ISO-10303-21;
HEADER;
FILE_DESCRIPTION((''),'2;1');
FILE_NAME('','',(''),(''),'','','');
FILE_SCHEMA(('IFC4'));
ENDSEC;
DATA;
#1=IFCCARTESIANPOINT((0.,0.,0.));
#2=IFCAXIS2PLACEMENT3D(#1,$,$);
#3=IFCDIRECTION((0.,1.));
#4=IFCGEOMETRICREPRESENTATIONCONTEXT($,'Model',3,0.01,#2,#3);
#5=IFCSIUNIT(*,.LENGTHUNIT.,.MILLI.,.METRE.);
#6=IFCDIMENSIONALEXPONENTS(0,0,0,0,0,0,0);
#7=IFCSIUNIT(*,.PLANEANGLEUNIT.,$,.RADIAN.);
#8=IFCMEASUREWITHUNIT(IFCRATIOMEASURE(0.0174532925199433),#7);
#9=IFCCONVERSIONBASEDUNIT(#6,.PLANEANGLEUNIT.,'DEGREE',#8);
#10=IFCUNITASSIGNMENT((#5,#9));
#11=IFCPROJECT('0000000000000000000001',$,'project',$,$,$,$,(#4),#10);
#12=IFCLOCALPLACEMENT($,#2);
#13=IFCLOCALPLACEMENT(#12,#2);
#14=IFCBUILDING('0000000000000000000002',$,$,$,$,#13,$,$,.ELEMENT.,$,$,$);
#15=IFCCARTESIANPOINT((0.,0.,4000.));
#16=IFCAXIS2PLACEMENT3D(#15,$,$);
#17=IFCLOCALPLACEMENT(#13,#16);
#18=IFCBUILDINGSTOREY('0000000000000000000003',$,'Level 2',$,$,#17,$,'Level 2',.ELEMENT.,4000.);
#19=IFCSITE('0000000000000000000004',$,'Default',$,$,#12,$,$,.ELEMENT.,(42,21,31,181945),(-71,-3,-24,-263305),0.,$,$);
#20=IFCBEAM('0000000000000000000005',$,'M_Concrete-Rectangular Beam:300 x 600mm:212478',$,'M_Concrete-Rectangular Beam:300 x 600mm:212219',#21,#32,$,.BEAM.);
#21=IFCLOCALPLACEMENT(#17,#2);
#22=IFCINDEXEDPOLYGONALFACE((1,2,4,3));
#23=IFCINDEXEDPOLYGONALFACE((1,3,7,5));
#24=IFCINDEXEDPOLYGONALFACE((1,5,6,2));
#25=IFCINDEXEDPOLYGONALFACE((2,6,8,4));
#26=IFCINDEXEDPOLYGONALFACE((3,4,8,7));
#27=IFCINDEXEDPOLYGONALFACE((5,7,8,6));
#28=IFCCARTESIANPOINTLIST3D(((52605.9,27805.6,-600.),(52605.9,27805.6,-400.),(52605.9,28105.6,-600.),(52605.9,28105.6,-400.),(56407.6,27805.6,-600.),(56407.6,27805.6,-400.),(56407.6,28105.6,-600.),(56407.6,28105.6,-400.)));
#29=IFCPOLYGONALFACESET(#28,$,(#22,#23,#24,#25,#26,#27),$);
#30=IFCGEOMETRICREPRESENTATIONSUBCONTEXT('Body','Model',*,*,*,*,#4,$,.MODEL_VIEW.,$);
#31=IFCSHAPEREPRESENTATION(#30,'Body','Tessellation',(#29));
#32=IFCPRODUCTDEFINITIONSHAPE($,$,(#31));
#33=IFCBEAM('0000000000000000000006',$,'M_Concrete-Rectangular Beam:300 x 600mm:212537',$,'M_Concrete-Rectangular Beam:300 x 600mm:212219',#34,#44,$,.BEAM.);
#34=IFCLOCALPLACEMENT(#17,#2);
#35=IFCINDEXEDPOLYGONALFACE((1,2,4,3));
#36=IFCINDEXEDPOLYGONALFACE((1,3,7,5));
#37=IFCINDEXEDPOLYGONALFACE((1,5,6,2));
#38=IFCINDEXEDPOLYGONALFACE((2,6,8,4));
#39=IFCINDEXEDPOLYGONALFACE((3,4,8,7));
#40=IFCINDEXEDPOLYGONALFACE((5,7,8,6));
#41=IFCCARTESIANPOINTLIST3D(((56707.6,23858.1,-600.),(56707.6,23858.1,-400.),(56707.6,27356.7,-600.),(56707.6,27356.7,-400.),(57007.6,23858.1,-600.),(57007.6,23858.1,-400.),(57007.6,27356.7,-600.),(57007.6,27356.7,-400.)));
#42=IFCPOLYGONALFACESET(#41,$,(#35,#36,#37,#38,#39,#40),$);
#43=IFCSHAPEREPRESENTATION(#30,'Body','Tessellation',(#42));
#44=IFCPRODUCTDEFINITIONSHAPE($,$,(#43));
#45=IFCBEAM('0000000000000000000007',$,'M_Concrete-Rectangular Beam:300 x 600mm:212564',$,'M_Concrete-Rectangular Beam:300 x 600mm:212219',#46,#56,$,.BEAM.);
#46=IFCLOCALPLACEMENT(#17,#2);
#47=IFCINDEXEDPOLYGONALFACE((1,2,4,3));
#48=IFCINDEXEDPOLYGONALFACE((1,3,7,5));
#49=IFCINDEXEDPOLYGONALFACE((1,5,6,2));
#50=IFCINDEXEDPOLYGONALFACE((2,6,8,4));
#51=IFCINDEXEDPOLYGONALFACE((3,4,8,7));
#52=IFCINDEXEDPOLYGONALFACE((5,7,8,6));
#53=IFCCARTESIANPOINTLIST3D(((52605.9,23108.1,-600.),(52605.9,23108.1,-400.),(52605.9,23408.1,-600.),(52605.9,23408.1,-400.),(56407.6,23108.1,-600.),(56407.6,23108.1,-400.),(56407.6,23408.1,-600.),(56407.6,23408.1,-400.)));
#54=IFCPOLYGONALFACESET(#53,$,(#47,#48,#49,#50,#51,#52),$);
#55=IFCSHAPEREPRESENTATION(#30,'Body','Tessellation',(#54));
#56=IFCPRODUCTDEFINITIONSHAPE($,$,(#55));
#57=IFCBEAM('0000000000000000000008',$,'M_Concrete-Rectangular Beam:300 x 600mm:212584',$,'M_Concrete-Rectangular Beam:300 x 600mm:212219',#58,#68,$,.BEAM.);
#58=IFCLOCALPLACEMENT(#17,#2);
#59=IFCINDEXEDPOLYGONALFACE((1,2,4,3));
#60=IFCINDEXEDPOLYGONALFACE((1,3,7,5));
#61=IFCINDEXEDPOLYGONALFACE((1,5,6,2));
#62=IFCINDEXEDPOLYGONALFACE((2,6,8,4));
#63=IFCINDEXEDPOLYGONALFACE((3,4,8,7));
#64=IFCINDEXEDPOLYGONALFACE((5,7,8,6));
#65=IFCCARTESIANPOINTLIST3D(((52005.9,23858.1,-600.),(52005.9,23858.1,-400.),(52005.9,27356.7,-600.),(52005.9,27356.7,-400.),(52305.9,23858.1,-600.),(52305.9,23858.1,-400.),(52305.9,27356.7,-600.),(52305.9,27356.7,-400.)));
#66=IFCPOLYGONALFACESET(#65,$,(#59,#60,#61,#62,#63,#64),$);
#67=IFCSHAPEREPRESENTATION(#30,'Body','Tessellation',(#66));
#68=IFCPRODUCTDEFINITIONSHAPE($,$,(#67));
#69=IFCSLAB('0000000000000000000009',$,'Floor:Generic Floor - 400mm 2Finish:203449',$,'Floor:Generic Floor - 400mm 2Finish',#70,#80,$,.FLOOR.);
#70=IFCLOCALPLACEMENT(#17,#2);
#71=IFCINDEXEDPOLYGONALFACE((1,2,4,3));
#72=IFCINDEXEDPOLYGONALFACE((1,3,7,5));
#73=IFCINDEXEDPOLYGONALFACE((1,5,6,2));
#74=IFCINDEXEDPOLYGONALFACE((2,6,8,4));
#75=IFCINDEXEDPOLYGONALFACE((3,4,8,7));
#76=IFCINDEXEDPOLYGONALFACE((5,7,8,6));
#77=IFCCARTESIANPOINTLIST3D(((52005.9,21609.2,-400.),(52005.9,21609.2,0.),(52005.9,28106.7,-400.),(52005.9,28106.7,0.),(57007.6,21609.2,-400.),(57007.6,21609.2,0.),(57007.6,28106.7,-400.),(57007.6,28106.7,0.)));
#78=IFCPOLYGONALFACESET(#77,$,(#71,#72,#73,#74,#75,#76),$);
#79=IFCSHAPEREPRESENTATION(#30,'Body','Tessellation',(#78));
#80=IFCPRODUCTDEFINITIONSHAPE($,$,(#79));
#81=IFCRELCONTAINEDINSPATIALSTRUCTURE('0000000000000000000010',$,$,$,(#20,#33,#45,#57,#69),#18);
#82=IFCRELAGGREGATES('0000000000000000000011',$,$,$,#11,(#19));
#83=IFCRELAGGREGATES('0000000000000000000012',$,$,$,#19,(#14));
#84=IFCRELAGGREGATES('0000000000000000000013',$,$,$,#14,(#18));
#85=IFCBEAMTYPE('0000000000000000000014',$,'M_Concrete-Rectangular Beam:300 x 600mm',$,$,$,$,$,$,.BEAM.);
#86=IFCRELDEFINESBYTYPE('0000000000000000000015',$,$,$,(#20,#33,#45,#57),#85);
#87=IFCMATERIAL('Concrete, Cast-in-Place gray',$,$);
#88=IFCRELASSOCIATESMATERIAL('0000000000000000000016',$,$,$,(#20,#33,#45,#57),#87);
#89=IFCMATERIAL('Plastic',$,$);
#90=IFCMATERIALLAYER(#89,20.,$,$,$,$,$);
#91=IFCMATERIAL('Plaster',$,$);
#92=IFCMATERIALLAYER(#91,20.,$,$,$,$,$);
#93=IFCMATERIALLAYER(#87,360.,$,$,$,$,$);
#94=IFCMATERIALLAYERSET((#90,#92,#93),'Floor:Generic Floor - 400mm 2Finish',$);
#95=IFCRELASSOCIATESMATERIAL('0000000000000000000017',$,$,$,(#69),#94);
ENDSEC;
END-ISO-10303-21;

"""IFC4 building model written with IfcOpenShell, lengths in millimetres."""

from ifc_helpers import new_model, entity, si_unit, converted_unit, direction, frame, frame_2d, origin, origin_2d_with_axis, place, context, subcontext, project, spatial, rectangle, extrude, material, layer, layer_set, layer_usage, type_object, element, save


model = new_model("IFC4")

# Units and contexts
model_context = context("Model", 3, precision=0.01, world=origin(), true_north=direction((0.0, 1.0)))
body_context = subcontext(model_context, "Body", "Model", "MODEL_VIEW")
ifc_project = project(units=[si_unit("LENGTHUNIT", "METRE", prefix="MILLI"), converted_unit("PLANEANGLEUNIT", "DEGREE", entity("IfcRatioMeasure", 0.0174532925199433), si_unit("PLANEANGLEUNIT", "RADIAN"), dimensions=[0, 0, 0, 0, 0, 0, 0])], contexts=[model_context])

# Site, building, storey
site_placement = place(None, origin())
site = spatial("IfcSite", under=ifc_project, at=site_placement, Name="Default", CompositionType="ELEMENT", RefLatitude=(42, 21, 31, 181945), RefLongitude=(-71, -3, -24, -263305), RefElevation=0.0)
building_placement = place(site_placement, origin())
building = spatial("IfcBuilding", under=site, at=building_placement, CompositionType="ELEMENT")
storey_placement = place(building_placement, frame((0.0, 0.0, 4000.0)))
storey = spatial("IfcBuildingStorey", under=building, at=storey_placement, Name="Level 2", LongName="Level 2", CompositionType="ELEMENT", Elevation=4000.0)

# Beams
ifc_material_1 = material(Name="Concrete, Cast-in-Place gray")
beam_type = type_object("IfcBeamType", Name="M_Concrete-Rectangular Beam:300 x 600mm", PredefinedType="BEAM")
beam_1_placement = place(storey_placement, frame((56407.6, 27955.6, 0.0), z_axis=(0.0, 0.0, 1.0), x_axis=(-1.0, 0.0, 0.0)))
element("IfcBeam", 1, at=beam_1_placement, inside=storey, type_object=beam_type, material=ifc_material_1, Name="M_Concrete-Rectangular Beam:300 x 600mm:212478", ObjectType="M_Concrete-Rectangular Beam:300 x 600mm:212219", PredefinedType="BEAM", context=body_context, shape_type="SweptSolid", body=[
    extrude(rectangle(XDim=200.0, YDim=300.0, at=frame_2d((0.0, 0.0), x_axis=(1.0, 0.0))), frame((0.0, 0.0, -500.0), z_axis=(1.0, 0.0, 0.0), x_axis=(0.0, 0.0, -1.0)), (0.0, 0.0, 1.0), 3801.7),
])
beam_2_placement = place(storey_placement, frame((56857.6, 27356.7, 0.0), z_axis=(0.0, 0.0, 1.0), x_axis=(0.0, -1.0, 0.0)))
element("IfcBeam", 2, at=beam_2_placement, inside=storey, type_object=beam_type, material=ifc_material_1, Name="M_Concrete-Rectangular Beam:300 x 600mm:212537", ObjectType="M_Concrete-Rectangular Beam:300 x 600mm:212219", PredefinedType="BEAM", context=body_context, shape_type="SweptSolid", body=[
    extrude(rectangle(XDim=200.0, YDim=300.0, at=frame_2d((0.0, 0.0), x_axis=(1.0, 0.0))), frame((0.0, 0.0, -500.0), z_axis=(1.0, 0.0, 0.0), x_axis=(0.0, 0.0, -1.0)), (0.0, 0.0, 1.0), 3498.6),
])
beam_3_placement = place(storey_placement, frame((56407.6, 23258.1, 0.0), z_axis=(0.0, 0.0, 1.0), x_axis=(-1.0, 0.0, 0.0)))
element("IfcBeam", 3, at=beam_3_placement, inside=storey, type_object=beam_type, material=ifc_material_1, Name="M_Concrete-Rectangular Beam:300 x 600mm:212564", ObjectType="M_Concrete-Rectangular Beam:300 x 600mm:212219", PredefinedType="BEAM", context=body_context, shape_type="SweptSolid", body=[
    extrude(rectangle(XDim=200.0, YDim=300.0, at=frame_2d((0.0, 0.0), x_axis=(1.0, 0.0))), frame((0.0, 0.0, -500.0), z_axis=(1.0, 0.0, 0.0), x_axis=(0.0, 0.0, -1.0)), (0.0, 0.0, 1.0), 3801.7),
])
beam_4_placement = place(storey_placement, frame((52155.9, 23858.1, 0.0), z_axis=(0.0, 0.0, 1.0), x_axis=(0.0, 1.0, 0.0)))
element("IfcBeam", 4, at=beam_4_placement, inside=storey, type_object=beam_type, material=ifc_material_1, Name="M_Concrete-Rectangular Beam:300 x 600mm:212584", ObjectType="M_Concrete-Rectangular Beam:300 x 600mm:212219", PredefinedType="BEAM", context=body_context, shape_type="SweptSolid", body=[
    extrude(rectangle(XDim=200.0, YDim=300.0, at=frame_2d((0.0, 0.0), x_axis=(1.0, 0.0))), frame((0.0, 0.0, -500.0), z_axis=(1.0, 0.0, 0.0), x_axis=(0.0, 0.0, -1.0)), (0.0, 0.0, 1.0), 3498.6),
])

# Slab
ifc_material_2 = material(Name="Plastic")
ifc_layer_1 = layer(ifc_material_2, 20.0)
ifc_material_3 = material(Name="Plaster")
ifc_layer_2 = layer(ifc_material_3, 20.0)
ifc_layer_3 = layer(ifc_material_1, 360.0)
ifc_layer_set = layer_set([ifc_layer_1, ifc_layer_2, ifc_layer_3], Name="Floor:Generic Floor - 400mm 2Finish")
ifc_layer_usage = layer_usage(ifc_layer_set, "AXIS3", "POSITIVE", 0.0)
slab_placement = place(storey_placement, origin())
element("IfcSlab", 5, at=slab_placement, inside=storey, material=ifc_layer_usage, Name="Floor:Generic Floor - 400mm 2Finish:203449", ObjectType="Floor:Generic Floor - 400mm 2Finish", PredefinedType="FLOOR", context=body_context, shape_type="SweptSolid", body=[
    extrude(rectangle(XDim=6497.5, YDim=5001.7, at=origin_2d_with_axis()), frame((54506.7, 24857.9, 0.0), z_axis=(0.0, 0.0, -1.0), x_axis=(0.0, 1.0, 0.0)), (0.0, 0.0, 1.0), 400.0),
])

save(model, "model.ifc")
